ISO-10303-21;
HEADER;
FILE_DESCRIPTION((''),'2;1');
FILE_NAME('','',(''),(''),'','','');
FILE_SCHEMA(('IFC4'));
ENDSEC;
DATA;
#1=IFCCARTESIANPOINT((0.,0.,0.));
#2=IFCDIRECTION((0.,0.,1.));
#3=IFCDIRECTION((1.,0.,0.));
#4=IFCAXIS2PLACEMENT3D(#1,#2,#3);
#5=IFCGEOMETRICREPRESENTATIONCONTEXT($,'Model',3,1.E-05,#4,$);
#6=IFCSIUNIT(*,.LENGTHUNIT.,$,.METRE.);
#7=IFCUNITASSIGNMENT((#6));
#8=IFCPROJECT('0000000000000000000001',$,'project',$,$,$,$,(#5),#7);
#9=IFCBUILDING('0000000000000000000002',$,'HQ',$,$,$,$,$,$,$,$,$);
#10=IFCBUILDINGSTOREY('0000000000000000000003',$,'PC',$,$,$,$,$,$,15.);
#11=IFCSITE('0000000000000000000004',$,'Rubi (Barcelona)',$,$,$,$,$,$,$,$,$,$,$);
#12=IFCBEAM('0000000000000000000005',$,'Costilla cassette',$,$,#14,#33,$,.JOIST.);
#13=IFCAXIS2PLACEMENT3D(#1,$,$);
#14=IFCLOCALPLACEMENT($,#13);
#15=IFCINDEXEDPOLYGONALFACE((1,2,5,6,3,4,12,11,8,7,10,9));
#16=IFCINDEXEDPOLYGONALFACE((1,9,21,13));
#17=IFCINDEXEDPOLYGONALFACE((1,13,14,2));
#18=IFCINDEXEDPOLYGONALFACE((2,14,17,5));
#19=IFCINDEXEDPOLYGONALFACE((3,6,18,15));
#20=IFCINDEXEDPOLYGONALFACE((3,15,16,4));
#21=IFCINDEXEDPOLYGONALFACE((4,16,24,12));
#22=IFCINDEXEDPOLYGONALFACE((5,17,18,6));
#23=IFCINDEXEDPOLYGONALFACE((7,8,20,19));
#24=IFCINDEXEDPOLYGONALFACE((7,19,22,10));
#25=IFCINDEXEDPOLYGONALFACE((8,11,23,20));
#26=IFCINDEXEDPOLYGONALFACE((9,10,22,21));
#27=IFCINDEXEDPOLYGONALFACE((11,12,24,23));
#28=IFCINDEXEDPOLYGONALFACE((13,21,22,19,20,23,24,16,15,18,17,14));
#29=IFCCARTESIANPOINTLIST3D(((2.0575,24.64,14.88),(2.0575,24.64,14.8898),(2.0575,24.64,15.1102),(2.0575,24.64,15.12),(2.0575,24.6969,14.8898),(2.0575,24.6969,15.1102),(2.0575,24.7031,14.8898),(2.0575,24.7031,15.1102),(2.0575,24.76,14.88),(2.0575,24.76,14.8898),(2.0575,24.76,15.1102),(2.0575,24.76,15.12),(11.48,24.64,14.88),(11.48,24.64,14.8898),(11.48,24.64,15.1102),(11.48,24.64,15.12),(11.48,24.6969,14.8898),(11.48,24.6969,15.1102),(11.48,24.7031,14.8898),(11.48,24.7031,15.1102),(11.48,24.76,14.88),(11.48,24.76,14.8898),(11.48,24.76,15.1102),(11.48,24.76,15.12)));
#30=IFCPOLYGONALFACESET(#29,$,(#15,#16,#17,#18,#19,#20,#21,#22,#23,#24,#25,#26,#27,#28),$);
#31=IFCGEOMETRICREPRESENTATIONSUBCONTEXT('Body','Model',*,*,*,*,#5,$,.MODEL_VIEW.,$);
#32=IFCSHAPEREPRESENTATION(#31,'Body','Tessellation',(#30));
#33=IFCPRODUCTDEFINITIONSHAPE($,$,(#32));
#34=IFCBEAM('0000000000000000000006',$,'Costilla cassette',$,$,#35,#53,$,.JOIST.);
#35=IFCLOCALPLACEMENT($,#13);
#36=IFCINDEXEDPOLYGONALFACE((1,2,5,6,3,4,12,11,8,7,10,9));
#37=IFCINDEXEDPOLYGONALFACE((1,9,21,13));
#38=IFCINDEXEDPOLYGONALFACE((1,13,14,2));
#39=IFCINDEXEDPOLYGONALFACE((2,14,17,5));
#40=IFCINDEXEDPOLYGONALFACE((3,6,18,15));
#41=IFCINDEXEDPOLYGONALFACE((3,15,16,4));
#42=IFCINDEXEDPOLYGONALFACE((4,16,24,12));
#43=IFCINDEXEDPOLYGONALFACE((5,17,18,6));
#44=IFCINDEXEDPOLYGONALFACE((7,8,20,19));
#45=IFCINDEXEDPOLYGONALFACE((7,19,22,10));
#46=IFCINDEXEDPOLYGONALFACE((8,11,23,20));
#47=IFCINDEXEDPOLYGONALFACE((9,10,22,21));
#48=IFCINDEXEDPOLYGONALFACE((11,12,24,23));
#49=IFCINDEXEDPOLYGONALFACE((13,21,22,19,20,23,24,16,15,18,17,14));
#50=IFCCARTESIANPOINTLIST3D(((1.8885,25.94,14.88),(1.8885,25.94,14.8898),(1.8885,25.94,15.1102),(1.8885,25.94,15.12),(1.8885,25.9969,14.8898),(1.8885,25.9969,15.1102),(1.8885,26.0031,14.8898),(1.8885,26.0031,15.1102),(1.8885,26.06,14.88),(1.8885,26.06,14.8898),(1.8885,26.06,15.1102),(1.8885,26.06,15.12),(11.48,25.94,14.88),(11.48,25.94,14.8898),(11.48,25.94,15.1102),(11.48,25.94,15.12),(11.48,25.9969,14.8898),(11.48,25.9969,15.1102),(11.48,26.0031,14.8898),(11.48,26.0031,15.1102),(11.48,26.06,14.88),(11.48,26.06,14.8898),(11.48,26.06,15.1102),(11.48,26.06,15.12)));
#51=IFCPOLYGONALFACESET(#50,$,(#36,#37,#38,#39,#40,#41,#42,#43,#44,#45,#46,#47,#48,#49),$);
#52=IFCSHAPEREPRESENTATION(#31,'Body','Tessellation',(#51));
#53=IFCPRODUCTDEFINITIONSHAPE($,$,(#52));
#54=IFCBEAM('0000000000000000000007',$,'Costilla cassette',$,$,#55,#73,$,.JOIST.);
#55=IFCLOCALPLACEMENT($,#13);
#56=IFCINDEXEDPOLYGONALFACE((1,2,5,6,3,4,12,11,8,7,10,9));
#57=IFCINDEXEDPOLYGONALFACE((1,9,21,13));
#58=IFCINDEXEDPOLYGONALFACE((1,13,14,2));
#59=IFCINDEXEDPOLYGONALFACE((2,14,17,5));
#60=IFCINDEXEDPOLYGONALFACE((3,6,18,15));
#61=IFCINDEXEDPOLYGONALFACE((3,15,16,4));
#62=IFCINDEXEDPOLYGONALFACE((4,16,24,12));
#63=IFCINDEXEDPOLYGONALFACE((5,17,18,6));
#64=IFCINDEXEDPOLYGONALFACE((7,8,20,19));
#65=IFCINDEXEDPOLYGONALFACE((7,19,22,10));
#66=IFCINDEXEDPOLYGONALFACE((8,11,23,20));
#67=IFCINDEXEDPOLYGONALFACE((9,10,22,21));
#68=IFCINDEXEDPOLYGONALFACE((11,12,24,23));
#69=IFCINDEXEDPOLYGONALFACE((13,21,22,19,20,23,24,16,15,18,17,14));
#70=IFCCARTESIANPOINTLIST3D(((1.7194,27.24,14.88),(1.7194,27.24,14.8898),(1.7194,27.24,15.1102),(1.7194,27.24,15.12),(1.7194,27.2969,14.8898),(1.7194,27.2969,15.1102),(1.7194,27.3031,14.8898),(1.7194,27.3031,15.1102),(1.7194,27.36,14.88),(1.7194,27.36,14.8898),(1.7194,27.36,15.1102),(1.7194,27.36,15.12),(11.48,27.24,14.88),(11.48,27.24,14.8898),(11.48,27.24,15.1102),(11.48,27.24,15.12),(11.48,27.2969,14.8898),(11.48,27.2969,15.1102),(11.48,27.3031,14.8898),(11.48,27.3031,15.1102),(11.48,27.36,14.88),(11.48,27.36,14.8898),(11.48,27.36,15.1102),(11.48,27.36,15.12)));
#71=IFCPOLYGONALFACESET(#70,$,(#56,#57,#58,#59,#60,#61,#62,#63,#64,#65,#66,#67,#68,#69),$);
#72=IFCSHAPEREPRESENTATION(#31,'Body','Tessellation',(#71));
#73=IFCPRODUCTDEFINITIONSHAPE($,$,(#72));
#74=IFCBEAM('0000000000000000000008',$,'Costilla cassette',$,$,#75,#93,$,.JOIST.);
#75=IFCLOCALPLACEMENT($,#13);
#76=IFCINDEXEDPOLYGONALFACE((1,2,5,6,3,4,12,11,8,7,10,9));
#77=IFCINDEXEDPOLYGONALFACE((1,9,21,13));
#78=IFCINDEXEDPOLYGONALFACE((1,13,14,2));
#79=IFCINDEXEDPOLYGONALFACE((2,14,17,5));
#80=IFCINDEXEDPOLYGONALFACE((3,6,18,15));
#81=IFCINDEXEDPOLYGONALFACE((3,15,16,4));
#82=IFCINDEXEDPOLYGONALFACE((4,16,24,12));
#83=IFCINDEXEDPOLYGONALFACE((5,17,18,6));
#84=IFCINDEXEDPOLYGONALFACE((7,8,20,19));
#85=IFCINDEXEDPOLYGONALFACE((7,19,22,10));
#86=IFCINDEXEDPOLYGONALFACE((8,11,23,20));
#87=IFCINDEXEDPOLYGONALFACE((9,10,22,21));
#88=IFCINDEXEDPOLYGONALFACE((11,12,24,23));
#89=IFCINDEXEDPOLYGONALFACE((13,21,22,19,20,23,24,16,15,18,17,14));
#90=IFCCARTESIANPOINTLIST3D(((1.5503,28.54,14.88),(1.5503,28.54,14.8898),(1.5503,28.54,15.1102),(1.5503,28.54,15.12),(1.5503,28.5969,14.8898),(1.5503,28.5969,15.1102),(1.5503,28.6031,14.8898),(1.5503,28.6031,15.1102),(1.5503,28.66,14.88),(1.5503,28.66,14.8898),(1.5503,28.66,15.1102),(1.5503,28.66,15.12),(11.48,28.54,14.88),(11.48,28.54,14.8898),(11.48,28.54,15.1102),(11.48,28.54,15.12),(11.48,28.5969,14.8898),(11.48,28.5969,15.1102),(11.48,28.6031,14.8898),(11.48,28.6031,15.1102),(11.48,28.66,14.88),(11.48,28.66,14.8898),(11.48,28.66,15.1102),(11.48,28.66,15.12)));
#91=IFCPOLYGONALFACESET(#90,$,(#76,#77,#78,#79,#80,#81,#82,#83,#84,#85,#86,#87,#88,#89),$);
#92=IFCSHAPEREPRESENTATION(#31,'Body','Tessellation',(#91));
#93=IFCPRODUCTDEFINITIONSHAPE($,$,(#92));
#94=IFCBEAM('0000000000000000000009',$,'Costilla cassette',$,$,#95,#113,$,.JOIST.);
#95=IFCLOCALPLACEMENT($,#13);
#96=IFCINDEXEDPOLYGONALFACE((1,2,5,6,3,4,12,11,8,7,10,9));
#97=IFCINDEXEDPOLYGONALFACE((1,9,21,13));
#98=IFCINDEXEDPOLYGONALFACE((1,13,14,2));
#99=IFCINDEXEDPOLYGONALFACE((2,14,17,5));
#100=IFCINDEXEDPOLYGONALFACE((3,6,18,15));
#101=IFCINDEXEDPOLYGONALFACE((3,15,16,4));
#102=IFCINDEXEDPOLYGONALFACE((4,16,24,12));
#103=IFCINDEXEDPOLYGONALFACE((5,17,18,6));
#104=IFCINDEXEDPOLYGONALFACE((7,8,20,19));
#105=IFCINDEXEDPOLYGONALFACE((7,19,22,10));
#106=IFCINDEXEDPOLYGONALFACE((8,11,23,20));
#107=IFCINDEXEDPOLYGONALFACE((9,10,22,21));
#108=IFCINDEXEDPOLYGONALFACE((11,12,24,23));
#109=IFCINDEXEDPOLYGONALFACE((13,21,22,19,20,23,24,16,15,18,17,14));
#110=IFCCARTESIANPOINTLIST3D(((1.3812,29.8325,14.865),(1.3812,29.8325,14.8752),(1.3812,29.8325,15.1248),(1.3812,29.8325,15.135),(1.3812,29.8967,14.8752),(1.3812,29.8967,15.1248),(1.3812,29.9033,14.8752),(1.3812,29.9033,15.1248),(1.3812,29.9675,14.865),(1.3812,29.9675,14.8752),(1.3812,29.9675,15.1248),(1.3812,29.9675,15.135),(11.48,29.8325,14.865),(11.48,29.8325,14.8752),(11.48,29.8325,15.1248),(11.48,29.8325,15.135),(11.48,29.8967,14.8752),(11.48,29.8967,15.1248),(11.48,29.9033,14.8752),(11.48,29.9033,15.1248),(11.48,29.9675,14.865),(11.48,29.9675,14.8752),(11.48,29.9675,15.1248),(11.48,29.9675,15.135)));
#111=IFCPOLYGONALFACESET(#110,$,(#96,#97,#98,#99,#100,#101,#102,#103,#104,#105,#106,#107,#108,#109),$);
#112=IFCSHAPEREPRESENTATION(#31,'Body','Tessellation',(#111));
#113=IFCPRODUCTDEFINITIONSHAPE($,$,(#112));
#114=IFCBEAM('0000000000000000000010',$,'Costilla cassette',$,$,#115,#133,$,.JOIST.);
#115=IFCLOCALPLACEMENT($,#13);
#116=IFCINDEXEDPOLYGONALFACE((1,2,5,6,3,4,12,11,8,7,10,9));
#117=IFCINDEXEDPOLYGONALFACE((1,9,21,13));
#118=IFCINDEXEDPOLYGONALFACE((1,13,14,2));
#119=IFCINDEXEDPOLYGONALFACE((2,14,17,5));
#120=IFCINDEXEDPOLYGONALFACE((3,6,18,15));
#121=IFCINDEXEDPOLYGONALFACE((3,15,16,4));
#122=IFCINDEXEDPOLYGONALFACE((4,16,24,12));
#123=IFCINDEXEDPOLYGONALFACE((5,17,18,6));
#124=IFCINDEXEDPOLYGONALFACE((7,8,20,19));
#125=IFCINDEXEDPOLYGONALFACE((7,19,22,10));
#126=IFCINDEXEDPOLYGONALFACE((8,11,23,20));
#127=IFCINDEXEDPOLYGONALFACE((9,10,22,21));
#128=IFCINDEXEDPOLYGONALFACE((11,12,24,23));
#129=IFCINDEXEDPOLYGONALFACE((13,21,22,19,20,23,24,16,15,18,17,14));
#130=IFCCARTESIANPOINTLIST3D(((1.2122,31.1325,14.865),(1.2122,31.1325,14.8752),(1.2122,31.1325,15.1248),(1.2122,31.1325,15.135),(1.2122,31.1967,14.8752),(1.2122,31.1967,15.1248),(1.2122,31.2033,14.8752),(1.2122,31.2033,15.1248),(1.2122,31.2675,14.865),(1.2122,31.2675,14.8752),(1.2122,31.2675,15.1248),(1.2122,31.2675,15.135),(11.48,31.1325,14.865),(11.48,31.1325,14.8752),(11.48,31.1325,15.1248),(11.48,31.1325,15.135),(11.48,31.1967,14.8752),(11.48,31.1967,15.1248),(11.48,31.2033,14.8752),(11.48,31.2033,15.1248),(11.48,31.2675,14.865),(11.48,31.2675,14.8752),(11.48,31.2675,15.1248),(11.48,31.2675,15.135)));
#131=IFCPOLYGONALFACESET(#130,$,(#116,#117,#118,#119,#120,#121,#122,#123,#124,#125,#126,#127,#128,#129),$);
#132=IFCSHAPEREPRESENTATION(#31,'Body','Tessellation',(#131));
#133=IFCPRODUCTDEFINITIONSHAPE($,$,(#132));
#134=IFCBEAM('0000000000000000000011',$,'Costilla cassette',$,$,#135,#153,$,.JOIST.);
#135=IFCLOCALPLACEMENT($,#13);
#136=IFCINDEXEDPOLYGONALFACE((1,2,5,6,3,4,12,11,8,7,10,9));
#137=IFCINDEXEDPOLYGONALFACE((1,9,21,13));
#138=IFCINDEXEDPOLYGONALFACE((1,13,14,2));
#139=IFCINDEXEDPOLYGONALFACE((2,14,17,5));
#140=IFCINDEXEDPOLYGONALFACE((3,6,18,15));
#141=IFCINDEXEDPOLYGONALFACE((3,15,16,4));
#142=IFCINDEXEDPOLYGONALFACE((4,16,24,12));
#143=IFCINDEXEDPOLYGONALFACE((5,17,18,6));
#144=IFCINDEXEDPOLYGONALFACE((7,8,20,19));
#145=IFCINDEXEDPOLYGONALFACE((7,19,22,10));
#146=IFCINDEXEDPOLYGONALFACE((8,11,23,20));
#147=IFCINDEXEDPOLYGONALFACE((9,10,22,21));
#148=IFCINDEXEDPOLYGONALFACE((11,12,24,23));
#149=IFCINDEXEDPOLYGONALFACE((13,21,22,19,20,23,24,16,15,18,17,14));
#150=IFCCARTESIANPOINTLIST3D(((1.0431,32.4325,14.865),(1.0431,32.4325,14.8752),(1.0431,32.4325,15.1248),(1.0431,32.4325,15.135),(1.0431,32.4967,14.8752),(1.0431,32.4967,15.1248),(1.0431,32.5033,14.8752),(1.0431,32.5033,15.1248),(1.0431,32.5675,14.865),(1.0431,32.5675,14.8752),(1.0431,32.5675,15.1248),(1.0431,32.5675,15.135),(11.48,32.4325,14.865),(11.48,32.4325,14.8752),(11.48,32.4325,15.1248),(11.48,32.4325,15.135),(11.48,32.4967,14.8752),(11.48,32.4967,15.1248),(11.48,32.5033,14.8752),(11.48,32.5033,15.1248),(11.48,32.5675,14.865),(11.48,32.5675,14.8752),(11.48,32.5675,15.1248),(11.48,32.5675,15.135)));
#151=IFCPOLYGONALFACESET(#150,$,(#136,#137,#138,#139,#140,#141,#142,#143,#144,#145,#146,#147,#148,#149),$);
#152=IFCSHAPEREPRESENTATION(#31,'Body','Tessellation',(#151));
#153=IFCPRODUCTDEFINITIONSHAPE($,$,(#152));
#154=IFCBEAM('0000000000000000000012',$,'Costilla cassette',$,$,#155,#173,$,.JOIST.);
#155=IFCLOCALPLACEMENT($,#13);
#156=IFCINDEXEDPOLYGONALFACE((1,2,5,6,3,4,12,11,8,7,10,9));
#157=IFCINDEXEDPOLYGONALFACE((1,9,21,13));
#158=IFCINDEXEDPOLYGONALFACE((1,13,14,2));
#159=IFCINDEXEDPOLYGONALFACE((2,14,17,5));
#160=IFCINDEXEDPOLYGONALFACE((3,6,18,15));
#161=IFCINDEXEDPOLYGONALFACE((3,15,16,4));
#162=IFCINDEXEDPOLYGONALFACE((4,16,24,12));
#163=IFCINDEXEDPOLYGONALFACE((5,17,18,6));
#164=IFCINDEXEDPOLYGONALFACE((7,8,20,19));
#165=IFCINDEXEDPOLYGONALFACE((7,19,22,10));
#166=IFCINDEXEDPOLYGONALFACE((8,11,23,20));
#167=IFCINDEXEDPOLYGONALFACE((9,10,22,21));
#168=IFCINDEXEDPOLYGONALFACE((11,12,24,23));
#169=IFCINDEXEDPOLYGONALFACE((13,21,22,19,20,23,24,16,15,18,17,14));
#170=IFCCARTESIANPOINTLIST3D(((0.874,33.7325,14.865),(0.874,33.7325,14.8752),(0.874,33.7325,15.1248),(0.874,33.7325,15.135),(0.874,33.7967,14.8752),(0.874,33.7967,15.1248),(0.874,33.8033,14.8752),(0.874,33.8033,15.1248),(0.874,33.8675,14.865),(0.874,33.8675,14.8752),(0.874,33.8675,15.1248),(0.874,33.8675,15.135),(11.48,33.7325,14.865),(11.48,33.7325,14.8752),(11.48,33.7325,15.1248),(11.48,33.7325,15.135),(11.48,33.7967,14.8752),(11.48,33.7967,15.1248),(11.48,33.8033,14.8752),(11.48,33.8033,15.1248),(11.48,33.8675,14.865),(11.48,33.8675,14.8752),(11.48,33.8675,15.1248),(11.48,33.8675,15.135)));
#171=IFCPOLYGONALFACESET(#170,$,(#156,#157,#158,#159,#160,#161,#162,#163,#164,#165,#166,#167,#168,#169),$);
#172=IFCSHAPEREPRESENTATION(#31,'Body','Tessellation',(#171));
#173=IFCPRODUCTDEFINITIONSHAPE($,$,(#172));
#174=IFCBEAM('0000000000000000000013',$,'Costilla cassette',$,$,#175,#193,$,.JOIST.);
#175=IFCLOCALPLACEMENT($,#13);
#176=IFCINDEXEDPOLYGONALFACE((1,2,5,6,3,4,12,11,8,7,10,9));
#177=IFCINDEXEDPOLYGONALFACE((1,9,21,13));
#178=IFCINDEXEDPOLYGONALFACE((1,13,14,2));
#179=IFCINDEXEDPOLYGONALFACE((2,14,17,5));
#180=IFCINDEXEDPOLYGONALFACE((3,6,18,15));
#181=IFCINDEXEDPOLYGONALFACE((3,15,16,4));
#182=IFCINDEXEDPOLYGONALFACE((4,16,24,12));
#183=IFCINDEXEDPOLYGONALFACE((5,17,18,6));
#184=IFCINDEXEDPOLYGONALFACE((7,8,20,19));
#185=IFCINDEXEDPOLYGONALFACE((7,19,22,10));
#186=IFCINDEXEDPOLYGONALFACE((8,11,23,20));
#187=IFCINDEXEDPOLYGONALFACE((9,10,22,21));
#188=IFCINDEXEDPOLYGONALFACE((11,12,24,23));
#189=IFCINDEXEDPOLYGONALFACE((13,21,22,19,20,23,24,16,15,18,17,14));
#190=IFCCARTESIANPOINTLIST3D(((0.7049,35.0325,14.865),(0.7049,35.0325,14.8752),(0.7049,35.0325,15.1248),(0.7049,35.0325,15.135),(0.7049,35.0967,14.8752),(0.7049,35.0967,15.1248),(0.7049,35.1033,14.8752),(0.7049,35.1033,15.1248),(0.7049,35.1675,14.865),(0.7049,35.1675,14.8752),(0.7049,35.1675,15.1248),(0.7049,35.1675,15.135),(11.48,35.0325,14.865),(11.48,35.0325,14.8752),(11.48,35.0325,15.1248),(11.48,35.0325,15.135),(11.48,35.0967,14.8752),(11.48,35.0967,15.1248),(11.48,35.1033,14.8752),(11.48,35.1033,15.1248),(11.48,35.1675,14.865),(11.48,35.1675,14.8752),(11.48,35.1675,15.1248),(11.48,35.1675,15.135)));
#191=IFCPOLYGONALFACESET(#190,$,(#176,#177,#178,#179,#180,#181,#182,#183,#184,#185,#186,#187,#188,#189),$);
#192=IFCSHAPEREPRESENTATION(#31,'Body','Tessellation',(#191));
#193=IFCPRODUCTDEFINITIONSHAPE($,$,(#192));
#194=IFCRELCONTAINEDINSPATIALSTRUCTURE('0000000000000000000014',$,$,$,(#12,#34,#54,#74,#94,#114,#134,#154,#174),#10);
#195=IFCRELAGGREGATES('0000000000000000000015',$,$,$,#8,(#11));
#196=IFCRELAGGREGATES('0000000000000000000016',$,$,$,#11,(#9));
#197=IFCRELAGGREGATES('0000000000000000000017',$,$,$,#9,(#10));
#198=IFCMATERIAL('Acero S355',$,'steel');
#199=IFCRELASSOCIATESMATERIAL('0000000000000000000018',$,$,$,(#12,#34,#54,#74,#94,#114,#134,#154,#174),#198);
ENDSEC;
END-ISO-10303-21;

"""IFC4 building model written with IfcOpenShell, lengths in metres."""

from ifc_helpers import new_model, si_unit, frame, origin_with_axes, place, context, subcontext, project, spatial, i_section, extrude, material, element, save


model = new_model("IFC4")

# Units and contexts
model_context = context("Model", 3, precision=1e-05, world=origin_with_axes())
body_context = subcontext(model_context, "Body", "Model", "MODEL_VIEW")
ifc_project = project(units=[si_unit("LENGTHUNIT", "METRE")], contexts=[model_context])

# Site, building, storey
site = spatial("IfcSite", under=ifc_project, Name="Rubi (Barcelona)")
building = spatial("IfcBuilding", under=site, Name="HQ")
storey = spatial("IfcBuildingStorey", under=building, Name="PC", Elevation=15.0)

# Beams
ifc_material_1 = material(Name="Acero S355", Category="steel")
beam_1_placement = place(None, origin_with_axes())
element("IfcBeam", 1, at=beam_1_placement, inside=storey, material=ifc_material_1, Name="Costilla cassette", PredefinedType="JOIST", context=body_context, shape_type="SweptSolid", body=[
    extrude(i_section(OverallWidth=0.12, OverallDepth=0.24, WebThickness=0.0062, FlangeThickness=0.0098), frame((2.0575, 24.7, 15.0), z_axis=(1.0, 0.0, 0.0), x_axis=(0.0, 1.0, 0.0)), (0.0, 0.0, 1.0), 9.4225),
])
beam_2_placement = place(None, origin_with_axes())
element("IfcBeam", 2, at=beam_2_placement, inside=storey, material=ifc_material_1, Name="Costilla cassette", PredefinedType="JOIST", context=body_context, shape_type="SweptSolid", body=[
    extrude(i_section(OverallWidth=0.12, OverallDepth=0.24, WebThickness=0.0062, FlangeThickness=0.0098), frame((1.8885, 26.0, 15.0), z_axis=(1.0, 0.0, 0.0), x_axis=(0.0, 1.0, 0.0)), (0.0, 0.0, 1.0), 9.5915),
])
beam_3_placement = place(None, origin_with_axes())
element("IfcBeam", 3, at=beam_3_placement, inside=storey, material=ifc_material_1, Name="Costilla cassette", PredefinedType="JOIST", context=body_context, shape_type="SweptSolid", body=[
    extrude(i_section(OverallWidth=0.12, OverallDepth=0.24, WebThickness=0.0062, FlangeThickness=0.0098), frame((1.7194, 27.3, 15.0), z_axis=(1.0, 0.0, 0.0), x_axis=(0.0, 1.0, 0.0)), (0.0, 0.0, 1.0), 9.7606),
])
beam_4_placement = place(None, origin_with_axes())
element("IfcBeam", 4, at=beam_4_placement, inside=storey, material=ifc_material_1, Name="Costilla cassette", PredefinedType="JOIST", context=body_context, shape_type="SweptSolid", body=[
    extrude(i_section(OverallWidth=0.12, OverallDepth=0.24, WebThickness=0.0062, FlangeThickness=0.0098), frame((1.5503, 28.6, 15.0), z_axis=(1.0, 0.0, 0.0), x_axis=(0.0, 1.0, 0.0)), (0.0, 0.0, 1.0), 9.9297),
])
beam_5_placement = place(None, origin_with_axes())
element("IfcBeam", 5, at=beam_5_placement, inside=storey, material=ifc_material_1, Name="Costilla cassette", PredefinedType="JOIST", context=body_context, shape_type="SweptSolid", body=[
    extrude(i_section(OverallWidth=0.135, OverallDepth=0.27, WebThickness=0.0066, FlangeThickness=0.0102), frame((1.3812, 29.9, 15.0), z_axis=(1.0, 0.0, 0.0), x_axis=(0.0, 1.0, 0.0)), (0.0, 0.0, 1.0), 10.0988),
])
beam_6_placement = place(None, origin_with_axes())
element("IfcBeam", 6, at=beam_6_placement, inside=storey, material=ifc_material_1, Name="Costilla cassette", PredefinedType="JOIST", context=body_context, shape_type="SweptSolid", body=[
    extrude(i_section(OverallWidth=0.135, OverallDepth=0.27, WebThickness=0.0066, FlangeThickness=0.0102), frame((1.2122, 31.2, 15.0), z_axis=(1.0, 0.0, 0.0), x_axis=(0.0, 1.0, 0.0)), (0.0, 0.0, 1.0), 10.2678),
])
beam_7_placement = place(None, origin_with_axes())
element("IfcBeam", 7, at=beam_7_placement, inside=storey, material=ifc_material_1, Name="Costilla cassette", PredefinedType="JOIST", context=body_context, shape_type="SweptSolid", body=[
    extrude(i_section(OverallWidth=0.135, OverallDepth=0.27, WebThickness=0.0066, FlangeThickness=0.0102), frame((1.0431, 32.5, 15.0), z_axis=(1.0, 0.0, 0.0), x_axis=(0.0, 1.0, 0.0)), (0.0, 0.0, 1.0), 10.4369),
])
beam_8_placement = place(None, origin_with_axes())
element("IfcBeam", 8, at=beam_8_placement, inside=storey, material=ifc_material_1, Name="Costilla cassette", PredefinedType="JOIST", context=body_context, shape_type="SweptSolid", body=[
    extrude(i_section(OverallWidth=0.135, OverallDepth=0.27, WebThickness=0.0066, FlangeThickness=0.0102), frame((0.874, 33.8, 15.0), z_axis=(1.0, 0.0, 0.0), x_axis=(0.0, 1.0, 0.0)), (0.0, 0.0, 1.0), 10.606),
])
beam_9_placement = place(None, origin_with_axes())
element("IfcBeam", 9, at=beam_9_placement, inside=storey, material=ifc_material_1, Name="Costilla cassette", PredefinedType="JOIST", context=body_context, shape_type="SweptSolid", body=[
    extrude(i_section(OverallWidth=0.135, OverallDepth=0.27, WebThickness=0.0066, FlangeThickness=0.0102), frame((0.7049, 35.1, 15.0), z_axis=(1.0, 0.0, 0.0), x_axis=(0.0, 1.0, 0.0)), (0.0, 0.0, 1.0), 10.7751),
])

save(model, "model.ifc")
